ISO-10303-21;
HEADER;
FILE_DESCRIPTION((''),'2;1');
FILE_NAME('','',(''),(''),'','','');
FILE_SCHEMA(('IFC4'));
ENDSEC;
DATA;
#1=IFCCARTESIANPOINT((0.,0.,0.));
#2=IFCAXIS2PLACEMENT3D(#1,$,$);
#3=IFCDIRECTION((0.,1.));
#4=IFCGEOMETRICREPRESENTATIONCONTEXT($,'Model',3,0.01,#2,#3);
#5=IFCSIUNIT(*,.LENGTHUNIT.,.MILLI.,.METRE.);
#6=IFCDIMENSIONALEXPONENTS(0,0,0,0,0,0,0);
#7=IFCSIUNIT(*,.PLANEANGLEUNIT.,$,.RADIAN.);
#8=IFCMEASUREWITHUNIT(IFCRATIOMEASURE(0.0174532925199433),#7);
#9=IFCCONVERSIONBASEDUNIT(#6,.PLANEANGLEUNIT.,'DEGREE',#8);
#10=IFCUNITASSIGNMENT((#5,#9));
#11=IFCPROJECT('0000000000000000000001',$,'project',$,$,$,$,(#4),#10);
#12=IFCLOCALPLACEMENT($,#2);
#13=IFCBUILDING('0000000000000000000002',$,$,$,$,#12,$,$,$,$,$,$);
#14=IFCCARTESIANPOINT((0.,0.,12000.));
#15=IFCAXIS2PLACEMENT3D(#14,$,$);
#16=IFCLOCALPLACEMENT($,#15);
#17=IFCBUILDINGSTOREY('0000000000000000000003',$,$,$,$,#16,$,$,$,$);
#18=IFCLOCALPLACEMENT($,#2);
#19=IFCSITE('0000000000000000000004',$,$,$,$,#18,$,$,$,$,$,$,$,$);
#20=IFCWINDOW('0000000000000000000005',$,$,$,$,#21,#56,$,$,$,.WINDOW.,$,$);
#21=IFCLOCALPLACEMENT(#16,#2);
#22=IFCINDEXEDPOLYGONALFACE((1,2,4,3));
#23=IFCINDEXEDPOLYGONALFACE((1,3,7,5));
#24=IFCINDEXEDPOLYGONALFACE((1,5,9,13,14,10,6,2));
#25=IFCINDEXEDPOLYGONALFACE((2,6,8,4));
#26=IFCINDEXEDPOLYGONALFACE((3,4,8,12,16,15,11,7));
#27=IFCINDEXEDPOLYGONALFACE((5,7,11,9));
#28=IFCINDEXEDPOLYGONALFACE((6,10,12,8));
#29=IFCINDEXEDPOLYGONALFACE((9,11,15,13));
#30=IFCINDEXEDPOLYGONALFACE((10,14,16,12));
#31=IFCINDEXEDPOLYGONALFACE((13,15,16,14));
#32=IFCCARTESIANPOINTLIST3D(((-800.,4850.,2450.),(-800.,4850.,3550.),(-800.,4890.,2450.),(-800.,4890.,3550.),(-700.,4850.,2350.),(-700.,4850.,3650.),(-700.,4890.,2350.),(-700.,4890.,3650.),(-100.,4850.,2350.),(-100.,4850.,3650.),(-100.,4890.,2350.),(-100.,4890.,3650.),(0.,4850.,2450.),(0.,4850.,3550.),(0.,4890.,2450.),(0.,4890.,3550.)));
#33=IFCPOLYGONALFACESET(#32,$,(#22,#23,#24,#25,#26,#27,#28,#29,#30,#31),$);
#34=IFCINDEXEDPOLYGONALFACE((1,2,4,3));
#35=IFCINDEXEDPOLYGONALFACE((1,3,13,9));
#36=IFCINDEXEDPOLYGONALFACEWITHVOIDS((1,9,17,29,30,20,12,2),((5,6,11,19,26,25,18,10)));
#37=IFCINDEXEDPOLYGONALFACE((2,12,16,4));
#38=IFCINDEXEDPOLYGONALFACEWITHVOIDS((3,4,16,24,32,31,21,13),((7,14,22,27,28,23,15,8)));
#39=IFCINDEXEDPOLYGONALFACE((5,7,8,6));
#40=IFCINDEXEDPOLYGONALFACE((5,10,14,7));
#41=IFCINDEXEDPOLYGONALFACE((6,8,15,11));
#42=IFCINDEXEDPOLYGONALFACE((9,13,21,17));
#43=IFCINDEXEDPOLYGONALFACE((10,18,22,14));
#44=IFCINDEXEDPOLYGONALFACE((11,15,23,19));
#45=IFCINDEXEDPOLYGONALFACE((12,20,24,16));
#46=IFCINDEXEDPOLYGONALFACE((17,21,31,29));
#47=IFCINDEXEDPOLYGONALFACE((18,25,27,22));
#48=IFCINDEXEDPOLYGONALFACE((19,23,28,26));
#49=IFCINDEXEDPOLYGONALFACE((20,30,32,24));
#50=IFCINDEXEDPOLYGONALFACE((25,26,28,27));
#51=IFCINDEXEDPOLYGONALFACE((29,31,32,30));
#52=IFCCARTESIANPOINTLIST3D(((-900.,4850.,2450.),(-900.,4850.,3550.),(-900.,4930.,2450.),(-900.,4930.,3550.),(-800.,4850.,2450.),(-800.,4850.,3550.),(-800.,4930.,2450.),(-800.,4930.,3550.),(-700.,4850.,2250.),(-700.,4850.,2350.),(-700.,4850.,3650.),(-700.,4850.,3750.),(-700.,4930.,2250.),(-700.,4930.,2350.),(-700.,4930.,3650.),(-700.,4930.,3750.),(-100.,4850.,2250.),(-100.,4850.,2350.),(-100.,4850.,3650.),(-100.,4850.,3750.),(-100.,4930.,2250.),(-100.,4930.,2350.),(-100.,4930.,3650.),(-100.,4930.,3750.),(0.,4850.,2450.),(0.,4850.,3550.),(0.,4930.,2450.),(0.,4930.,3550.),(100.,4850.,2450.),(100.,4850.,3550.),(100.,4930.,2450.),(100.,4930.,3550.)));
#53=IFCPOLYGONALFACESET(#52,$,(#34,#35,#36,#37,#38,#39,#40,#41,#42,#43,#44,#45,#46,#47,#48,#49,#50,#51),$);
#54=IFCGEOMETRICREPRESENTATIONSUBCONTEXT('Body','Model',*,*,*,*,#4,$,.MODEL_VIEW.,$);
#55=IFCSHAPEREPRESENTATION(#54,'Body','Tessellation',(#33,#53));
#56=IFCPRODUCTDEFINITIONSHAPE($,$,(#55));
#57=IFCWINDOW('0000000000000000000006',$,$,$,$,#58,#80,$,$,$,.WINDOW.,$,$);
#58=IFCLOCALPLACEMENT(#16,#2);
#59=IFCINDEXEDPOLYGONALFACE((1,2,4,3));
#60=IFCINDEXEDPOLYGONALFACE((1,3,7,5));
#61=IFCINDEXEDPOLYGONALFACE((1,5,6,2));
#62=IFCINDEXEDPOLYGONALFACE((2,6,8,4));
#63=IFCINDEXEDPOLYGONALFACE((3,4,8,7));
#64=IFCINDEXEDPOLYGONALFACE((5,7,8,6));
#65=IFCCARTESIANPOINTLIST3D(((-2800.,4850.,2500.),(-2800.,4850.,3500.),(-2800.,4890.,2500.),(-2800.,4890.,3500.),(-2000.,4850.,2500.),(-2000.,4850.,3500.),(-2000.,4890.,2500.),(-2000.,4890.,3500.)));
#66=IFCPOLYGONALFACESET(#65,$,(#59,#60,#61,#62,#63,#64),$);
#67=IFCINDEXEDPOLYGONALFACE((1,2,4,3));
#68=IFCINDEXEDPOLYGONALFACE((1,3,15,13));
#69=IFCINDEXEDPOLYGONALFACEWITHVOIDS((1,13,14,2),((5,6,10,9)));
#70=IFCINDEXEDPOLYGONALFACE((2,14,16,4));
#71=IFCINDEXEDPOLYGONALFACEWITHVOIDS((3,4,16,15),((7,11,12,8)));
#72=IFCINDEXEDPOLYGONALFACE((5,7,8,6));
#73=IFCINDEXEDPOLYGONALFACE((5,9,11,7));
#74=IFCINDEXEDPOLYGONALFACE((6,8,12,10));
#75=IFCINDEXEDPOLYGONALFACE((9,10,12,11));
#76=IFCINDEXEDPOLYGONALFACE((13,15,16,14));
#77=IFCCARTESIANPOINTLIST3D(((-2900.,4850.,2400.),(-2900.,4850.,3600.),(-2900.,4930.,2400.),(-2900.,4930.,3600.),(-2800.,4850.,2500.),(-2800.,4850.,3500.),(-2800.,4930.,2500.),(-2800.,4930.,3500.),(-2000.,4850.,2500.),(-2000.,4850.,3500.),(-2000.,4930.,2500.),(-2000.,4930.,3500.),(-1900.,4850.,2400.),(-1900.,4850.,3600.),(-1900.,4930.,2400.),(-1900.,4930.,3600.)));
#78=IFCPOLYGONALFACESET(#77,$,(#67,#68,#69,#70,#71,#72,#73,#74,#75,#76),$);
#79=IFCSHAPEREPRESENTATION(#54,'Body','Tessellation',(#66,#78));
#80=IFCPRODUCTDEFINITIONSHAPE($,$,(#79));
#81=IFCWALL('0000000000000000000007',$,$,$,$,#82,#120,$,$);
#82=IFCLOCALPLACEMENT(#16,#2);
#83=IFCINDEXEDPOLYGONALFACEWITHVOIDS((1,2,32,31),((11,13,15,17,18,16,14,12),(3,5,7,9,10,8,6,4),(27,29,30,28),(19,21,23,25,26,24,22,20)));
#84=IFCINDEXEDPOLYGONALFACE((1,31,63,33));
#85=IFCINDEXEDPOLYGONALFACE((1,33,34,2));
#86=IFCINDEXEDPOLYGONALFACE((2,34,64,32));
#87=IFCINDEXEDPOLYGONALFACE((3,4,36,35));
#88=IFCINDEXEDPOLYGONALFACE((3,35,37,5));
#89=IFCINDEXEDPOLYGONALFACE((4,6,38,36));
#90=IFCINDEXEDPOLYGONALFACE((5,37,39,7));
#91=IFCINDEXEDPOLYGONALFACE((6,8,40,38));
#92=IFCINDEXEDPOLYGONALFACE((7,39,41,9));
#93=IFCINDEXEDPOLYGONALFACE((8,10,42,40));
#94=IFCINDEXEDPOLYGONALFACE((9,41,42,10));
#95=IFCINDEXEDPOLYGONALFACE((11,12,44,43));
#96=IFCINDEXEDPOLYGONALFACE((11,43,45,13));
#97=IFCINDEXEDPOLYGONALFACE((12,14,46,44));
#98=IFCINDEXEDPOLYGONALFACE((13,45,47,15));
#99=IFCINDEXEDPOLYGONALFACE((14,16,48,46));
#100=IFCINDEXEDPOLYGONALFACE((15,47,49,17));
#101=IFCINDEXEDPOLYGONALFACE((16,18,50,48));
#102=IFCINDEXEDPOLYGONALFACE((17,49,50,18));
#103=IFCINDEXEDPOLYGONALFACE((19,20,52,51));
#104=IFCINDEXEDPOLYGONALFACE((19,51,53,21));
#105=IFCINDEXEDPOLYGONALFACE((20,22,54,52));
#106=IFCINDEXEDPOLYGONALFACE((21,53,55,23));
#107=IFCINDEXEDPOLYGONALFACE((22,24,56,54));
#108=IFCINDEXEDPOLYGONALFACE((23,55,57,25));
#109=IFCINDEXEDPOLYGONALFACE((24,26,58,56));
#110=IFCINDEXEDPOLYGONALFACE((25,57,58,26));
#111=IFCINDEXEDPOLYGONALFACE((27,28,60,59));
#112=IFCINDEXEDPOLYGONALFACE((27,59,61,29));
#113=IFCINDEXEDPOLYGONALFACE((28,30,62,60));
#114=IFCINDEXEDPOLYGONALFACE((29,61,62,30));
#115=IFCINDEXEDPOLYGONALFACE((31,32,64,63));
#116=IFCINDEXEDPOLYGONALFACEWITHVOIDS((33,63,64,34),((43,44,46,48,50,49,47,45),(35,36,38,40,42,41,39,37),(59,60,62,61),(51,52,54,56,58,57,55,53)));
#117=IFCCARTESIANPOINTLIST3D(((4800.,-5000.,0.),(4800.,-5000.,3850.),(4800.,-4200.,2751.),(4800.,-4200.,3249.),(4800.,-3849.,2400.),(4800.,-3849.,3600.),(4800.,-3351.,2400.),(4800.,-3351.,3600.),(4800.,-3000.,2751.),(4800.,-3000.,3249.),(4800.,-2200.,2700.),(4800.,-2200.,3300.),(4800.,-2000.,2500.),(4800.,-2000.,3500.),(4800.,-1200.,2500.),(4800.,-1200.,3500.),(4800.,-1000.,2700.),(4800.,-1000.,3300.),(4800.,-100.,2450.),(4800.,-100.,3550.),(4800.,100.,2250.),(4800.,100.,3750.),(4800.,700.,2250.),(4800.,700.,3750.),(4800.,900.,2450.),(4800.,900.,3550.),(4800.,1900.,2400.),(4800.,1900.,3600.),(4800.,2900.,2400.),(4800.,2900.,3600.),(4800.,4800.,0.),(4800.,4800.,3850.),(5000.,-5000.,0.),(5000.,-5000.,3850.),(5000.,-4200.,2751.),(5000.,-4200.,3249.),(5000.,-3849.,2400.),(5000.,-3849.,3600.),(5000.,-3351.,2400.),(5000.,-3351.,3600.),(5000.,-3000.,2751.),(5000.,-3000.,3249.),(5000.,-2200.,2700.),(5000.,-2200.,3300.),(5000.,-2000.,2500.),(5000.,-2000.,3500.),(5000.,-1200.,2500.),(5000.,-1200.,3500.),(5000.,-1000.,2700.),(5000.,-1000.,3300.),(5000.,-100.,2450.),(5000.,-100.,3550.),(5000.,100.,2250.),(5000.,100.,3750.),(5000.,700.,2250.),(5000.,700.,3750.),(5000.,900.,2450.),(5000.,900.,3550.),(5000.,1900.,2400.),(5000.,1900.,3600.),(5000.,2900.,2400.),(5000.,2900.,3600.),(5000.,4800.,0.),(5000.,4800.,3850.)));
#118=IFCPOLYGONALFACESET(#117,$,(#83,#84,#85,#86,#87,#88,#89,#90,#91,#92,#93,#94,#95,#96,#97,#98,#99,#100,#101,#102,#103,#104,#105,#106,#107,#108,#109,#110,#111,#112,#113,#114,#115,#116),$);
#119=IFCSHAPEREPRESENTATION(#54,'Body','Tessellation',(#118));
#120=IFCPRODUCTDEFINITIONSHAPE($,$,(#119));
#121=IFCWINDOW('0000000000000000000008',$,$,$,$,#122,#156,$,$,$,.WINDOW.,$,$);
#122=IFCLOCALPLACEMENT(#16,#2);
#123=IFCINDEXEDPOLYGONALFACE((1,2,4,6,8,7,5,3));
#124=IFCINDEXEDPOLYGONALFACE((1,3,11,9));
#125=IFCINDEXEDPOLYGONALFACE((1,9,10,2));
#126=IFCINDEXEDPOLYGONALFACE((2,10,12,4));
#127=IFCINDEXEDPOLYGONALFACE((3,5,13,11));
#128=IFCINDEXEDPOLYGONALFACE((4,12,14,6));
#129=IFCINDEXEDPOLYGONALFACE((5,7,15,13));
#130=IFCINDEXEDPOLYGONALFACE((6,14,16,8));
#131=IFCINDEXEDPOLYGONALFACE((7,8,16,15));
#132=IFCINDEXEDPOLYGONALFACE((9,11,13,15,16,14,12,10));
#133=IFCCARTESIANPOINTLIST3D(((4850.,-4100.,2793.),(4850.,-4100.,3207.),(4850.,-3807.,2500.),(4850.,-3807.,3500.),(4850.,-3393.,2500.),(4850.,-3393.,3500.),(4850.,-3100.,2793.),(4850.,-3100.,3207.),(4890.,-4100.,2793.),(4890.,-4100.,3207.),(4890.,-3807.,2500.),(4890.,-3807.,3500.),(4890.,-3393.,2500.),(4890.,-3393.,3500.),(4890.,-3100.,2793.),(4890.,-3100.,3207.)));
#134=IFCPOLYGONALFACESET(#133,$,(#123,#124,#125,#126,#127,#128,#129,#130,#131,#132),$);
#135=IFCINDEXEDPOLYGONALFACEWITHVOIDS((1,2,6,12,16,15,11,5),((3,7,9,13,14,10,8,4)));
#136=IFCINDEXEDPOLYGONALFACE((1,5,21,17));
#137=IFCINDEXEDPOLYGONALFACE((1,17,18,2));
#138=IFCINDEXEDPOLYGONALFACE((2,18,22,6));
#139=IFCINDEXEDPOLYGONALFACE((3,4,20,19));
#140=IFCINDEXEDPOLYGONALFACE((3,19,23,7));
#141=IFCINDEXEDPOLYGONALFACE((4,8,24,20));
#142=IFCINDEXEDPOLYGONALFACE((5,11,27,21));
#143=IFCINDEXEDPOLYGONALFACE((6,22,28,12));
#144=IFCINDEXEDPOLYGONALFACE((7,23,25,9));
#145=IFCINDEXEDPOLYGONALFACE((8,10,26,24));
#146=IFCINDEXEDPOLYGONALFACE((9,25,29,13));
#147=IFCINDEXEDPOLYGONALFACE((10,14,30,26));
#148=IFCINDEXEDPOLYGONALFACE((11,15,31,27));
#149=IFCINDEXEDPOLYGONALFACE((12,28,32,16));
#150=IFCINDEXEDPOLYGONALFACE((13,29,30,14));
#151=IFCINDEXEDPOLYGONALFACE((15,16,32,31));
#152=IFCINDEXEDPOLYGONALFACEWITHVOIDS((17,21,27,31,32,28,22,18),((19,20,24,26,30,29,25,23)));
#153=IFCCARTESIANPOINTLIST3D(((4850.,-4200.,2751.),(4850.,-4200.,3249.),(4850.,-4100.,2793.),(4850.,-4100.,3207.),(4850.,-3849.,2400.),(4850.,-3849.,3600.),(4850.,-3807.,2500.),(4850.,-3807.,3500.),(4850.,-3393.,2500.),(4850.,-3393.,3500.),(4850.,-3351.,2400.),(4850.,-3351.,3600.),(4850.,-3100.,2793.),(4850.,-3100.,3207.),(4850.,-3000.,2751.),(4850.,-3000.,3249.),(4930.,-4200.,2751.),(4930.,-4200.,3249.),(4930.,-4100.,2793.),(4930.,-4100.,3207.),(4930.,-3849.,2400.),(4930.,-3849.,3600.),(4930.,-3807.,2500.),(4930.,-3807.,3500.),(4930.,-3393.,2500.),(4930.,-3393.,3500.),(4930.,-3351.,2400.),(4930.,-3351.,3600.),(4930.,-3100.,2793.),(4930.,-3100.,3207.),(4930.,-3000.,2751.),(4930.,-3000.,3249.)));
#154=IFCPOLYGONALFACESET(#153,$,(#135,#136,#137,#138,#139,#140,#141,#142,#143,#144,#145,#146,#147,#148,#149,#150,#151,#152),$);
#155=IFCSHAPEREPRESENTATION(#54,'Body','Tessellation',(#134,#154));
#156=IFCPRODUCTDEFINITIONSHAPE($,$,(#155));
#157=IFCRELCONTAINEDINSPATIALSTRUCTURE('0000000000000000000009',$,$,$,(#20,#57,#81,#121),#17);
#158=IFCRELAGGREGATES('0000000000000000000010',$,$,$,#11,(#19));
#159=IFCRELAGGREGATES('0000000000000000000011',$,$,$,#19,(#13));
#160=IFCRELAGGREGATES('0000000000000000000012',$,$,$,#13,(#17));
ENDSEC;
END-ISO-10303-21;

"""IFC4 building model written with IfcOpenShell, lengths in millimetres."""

from ifc_helpers import new_model, entity, si_unit, converted_unit, direction, frame, origin, origin_2d, place, context, subcontext, project, spatial, polyline, rectangle, outline, extrude, element, save


model = new_model("IFC4")

# Units and contexts
model_context = context("Model", 3, precision=0.01, world=origin(), true_north=direction((0.0, 1.0)))
body_context = subcontext(model_context, "Body", "Model", "MODEL_VIEW")
ifc_project = project(units=[si_unit("LENGTHUNIT", "METRE", prefix="MILLI"), converted_unit("PLANEANGLEUNIT", "DEGREE", entity("IfcRatioMeasure", 0.0174532925199433), si_unit("PLANEANGLEUNIT", "RADIAN"), dimensions=[0, 0, 0, 0, 0, 0, 0])], contexts=[model_context])

# Site, building, storey
site_placement = place(None, origin())
site = spatial("IfcSite", under=ifc_project, at=site_placement)
building_placement = place(None, origin())
building = spatial("IfcBuilding", under=site, at=building_placement)
storey_placement = place(None, frame((0.0, 0.0, 12000.0)))
storey = spatial("IfcBuildingStorey", under=building, at=storey_placement)

# Shared definitions
wall_1_placement = place(storey_placement, frame((100.0, 4900.0, 0.0), z_axis=(0.0, 0.0, 1.0), x_axis=(-1.0, 0.0, 0.0)))
window_1_placement = place(wall_1_placement, frame((500.0, 50.0, 3000.0)))
window_2_placement = place(wall_1_placement, frame((2500.0, 50.0, 3000.0)))

# Windows
cartesian_point_1 = entity("IfcCartesianPoint", [-500.0, -207.0])
shared_polyline_1 = entity("IfcPolyline", [cartesian_point_1, entity("IfcCartesianPoint", [-500.0, 207.0]), entity("IfcCartesianPoint", [-207.0, 500.0]), entity("IfcCartesianPoint", [207.0, 500.0]), entity("IfcCartesianPoint", [500.0, 207.0]), entity("IfcCartesianPoint", [500.0, -207.0]), entity("IfcCartesianPoint", [207.0, -500.0]), entity("IfcCartesianPoint", [-207.0, -500.0]), cartesian_point_1])
cartesian_point_2 = entity("IfcCartesianPoint", [-400.0, -550.0])
shared_polyline_2 = entity("IfcPolyline", [cartesian_point_2, entity("IfcCartesianPoint", [-400.0, 550.0]), entity("IfcCartesianPoint", [-300.0, 650.0]), entity("IfcCartesianPoint", [300.0, 650.0]), entity("IfcCartesianPoint", [400.0, 550.0]), entity("IfcCartesianPoint", [400.0, -550.0]), entity("IfcCartesianPoint", [300.0, -650.0]), entity("IfcCartesianPoint", [-300.0, -650.0]), cartesian_point_2])
cartesian_point_3 = entity("IfcCartesianPoint", [-500.0, -550.0])
element("IfcWindow", 1, at=window_1_placement, inside=storey, PredefinedType="WINDOW", context=body_context, shape_type="SweptSolid", body=[
    entity("IfcExtrudedAreaSolid", entity("IfcArbitraryClosedProfileDef", "AREA", None, shared_polyline_2), entity("IfcAxis2Placement3D", entity("IfcCartesianPoint", [0.0, 0.0, 0.0]), entity("IfcDirection", [0.0, -1.0, 0.0]), entity("IfcDirection", [1.0, 0.0, 0.0])), entity("IfcDirection", [0.0, 0.0, 1.0]), 40.0),
    entity("IfcExtrudedAreaSolid", entity("IfcArbitraryProfileDefWithVoids", "AREA", None, entity("IfcPolyline", [cartesian_point_3, entity("IfcCartesianPoint", [-500.0, 550.0]), entity("IfcCartesianPoint", [-300.0, 750.0]), entity("IfcCartesianPoint", [300.0, 750.0]), entity("IfcCartesianPoint", [500.0, 550.0]), entity("IfcCartesianPoint", [500.0, -550.0]), entity("IfcCartesianPoint", [300.0, -750.0]), entity("IfcCartesianPoint", [-300.0, -750.0]), cartesian_point_3]), [shared_polyline_2]), entity("IfcAxis2Placement3D", entity("IfcCartesianPoint", [0.0, 0.0, 0.0]), entity("IfcDirection", [0.0, -1.0, 0.0]), entity("IfcDirection", [1.0, 0.0, 0.0])), entity("IfcDirection", [0.0, 0.0, 1.0]), 80.0),
])
cartesian_point_4 = entity("IfcCartesianPoint", [-400.0, -500.0])
shared_polyline_3 = entity("IfcPolyline", [cartesian_point_4, entity("IfcCartesianPoint", [-400.0, 500.0]), entity("IfcCartesianPoint", [-400.0, 500.0]), entity("IfcCartesianPoint", [400.0, 500.0]), entity("IfcCartesianPoint", [400.0, 500.0]), entity("IfcCartesianPoint", [400.0, -500.0]), entity("IfcCartesianPoint", [400.0, -500.0]), entity("IfcCartesianPoint", [-400.0, -500.0]), cartesian_point_4])
cartesian_point_5 = entity("IfcCartesianPoint", [-500.0, -600.0])
element("IfcWindow", 2, at=window_2_placement, inside=storey, PredefinedType="WINDOW", context=body_context, shape_type="SweptSolid", body=[
    entity("IfcExtrudedAreaSolid", entity("IfcArbitraryClosedProfileDef", "AREA", None, shared_polyline_3), entity("IfcAxis2Placement3D", entity("IfcCartesianPoint", [0.0, 0.0, 0.0]), entity("IfcDirection", [0.0, -1.0, 0.0]), entity("IfcDirection", [1.0, 0.0, 0.0])), entity("IfcDirection", [0.0, 0.0, 1.0]), 40.0),
    entity("IfcExtrudedAreaSolid", entity("IfcArbitraryProfileDefWithVoids", "AREA", None, entity("IfcPolyline", [cartesian_point_5, entity("IfcCartesianPoint", [-500.0, 600.0]), entity("IfcCartesianPoint", [-500.0, 600.0]), entity("IfcCartesianPoint", [500.0, 600.0]), entity("IfcCartesianPoint", [500.0, 600.0]), entity("IfcCartesianPoint", [500.0, -600.0]), entity("IfcCartesianPoint", [500.0, -600.0]), entity("IfcCartesianPoint", [-500.0, -600.0]), cartesian_point_5]), [shared_polyline_3]), entity("IfcAxis2Placement3D", entity("IfcCartesianPoint", [0.0, 0.0, 0.0]), entity("IfcDirection", [0.0, -1.0, 0.0]), entity("IfcDirection", [1.0, 0.0, 0.0])), entity("IfcDirection", [0.0, 0.0, 1.0]), 80.0),
])

# Wall, openings
wall_2_placement = place(storey_placement, frame((4900.0, -100.0, 0.0), z_axis=(0.0, 0.0, 1.0), x_axis=(0.0, 1.0, 0.0)))
wall_2 = element("IfcWall", 3, at=wall_2_placement, inside=storey, context=body_context, shape_type="SweptSolid", body=[
    extrude(rectangle(XDim=9800.0, YDim=200.0, at=origin_2d()), origin(), (0.0, 0.0, 1.0), 3850.0),
])
window_3_placement = place(wall_2_placement, frame((-3500.0, 50.0, 3000.0)))
opening_1_placement = place(window_3_placement, frame((0.0, 50.0, 0.0)))
element("IfcOpeningElement", 4, at=opening_1_placement, cuts=wall_2, context=body_context, shape_type="SweptSolid", body=[
    extrude(outline(polyline([(-600.0, -249.0), (-600.0, 249.0), (-249.0, 600.0), (249.0, 600.0), (600.0, 249.0), (600.0, -249.0), (249.0, -600.0), (-249.0, -600.0), (-600.0, -249.0)])), frame((0.0, 0.0, 0.0), z_axis=(0.0, -1.0, 0.0), x_axis=(1.0, 0.0, 0.0)), (0.0, 0.0, 1.0), 200.0),
])
window_4_placement = place(wall_2_placement, frame((-1500.0, 50.0, 3000.0)))
opening_2_placement = place(window_4_placement, frame((0.0, 50.0, 0.0)))
element("IfcOpeningElement", 5, at=opening_2_placement, cuts=wall_2, context=body_context, shape_type="SweptSolid", body=[
    extrude(outline(polyline([(-600.0, -300.0), (-600.0, 300.0), (-400.0, 500.0), (400.0, 500.0), (600.0, 300.0), (600.0, -300.0), (400.0, -500.0), (-400.0, -500.0), (-600.0, -300.0)])), frame((0.0, 0.0, 0.0), z_axis=(0.0, -1.0, 0.0), x_axis=(1.0, 0.0, 0.0)), (0.0, 0.0, 1.0), 200.0),
])
window_5_placement = place(wall_2_placement, frame((500.0, 50.0, 3000.0)))
opening_3_placement = place(window_5_placement, frame((0.0, 50.0, 0.0)))
element("IfcOpeningElement", 6, at=opening_3_placement, cuts=wall_2, context=body_context, shape_type="SweptSolid", body=[
    extrude(outline(polyline([(-500.0, -550.0), (-500.0, 550.0), (-300.0, 750.0), (300.0, 750.0), (500.0, 550.0), (500.0, -550.0), (300.0, -750.0), (-300.0, -750.0), (-500.0, -550.0)])), frame((0.0, 0.0, 0.0), z_axis=(0.0, -1.0, 0.0), x_axis=(1.0, 0.0, 0.0)), (0.0, 0.0, 1.0), 200.0),
])
window_6_placement = place(wall_2_placement, frame((2500.0, 50.0, 3000.0)))
opening_4_placement = place(window_6_placement, frame((0.0, 50.0, 0.0)))
element("IfcOpeningElement", 7, at=opening_4_placement, cuts=wall_2, context=body_context, shape_type="SweptSolid", body=[
    extrude(outline(polyline([(-500.0, -600.0), (-500.0, 600.0), (-500.0, 600.0), (500.0, 600.0), (500.0, 600.0), (500.0, -600.0), (500.0, -600.0), (-500.0, -600.0), (-500.0, -600.0)])), frame((0.0, 0.0, 0.0), z_axis=(0.0, -1.0, 0.0), x_axis=(1.0, 0.0, 0.0)), (0.0, 0.0, 1.0), 200.0),
])

# Window
cartesian_point_6 = entity("IfcCartesianPoint", [-600.0, -249.0])
element("IfcWindow", 8, at=window_3_placement, inside=storey, PredefinedType="WINDOW", context=body_context, shape_type="SweptSolid", body=[
    entity("IfcExtrudedAreaSolid", entity("IfcArbitraryClosedProfileDef", "AREA", None, shared_polyline_1), entity("IfcAxis2Placement3D", entity("IfcCartesianPoint", [0.0, 0.0, 0.0]), entity("IfcDirection", [0.0, -1.0, 0.0]), entity("IfcDirection", [1.0, 0.0, 0.0])), entity("IfcDirection", [0.0, 0.0, 1.0]), 40.0),
    entity("IfcExtrudedAreaSolid", entity("IfcArbitraryProfileDefWithVoids", "AREA", None, entity("IfcPolyline", [cartesian_point_6, entity("IfcCartesianPoint", [-600.0, 249.0]), entity("IfcCartesianPoint", [-249.0, 600.0]), entity("IfcCartesianPoint", [249.0, 600.0]), entity("IfcCartesianPoint", [600.0, 249.0]), entity("IfcCartesianPoint", [600.0, -249.0]), entity("IfcCartesianPoint", [249.0, -600.0]), entity("IfcCartesianPoint", [-249.0, -600.0]), cartesian_point_6]), [shared_polyline_1]), entity("IfcAxis2Placement3D", entity("IfcCartesianPoint", [0.0, 0.0, 0.0]), entity("IfcDirection", [0.0, -1.0, 0.0]), entity("IfcDirection", [1.0, 0.0, 0.0])), entity("IfcDirection", [0.0, 0.0, 1.0]), 80.0),
])

save(model, "model.ifc")
